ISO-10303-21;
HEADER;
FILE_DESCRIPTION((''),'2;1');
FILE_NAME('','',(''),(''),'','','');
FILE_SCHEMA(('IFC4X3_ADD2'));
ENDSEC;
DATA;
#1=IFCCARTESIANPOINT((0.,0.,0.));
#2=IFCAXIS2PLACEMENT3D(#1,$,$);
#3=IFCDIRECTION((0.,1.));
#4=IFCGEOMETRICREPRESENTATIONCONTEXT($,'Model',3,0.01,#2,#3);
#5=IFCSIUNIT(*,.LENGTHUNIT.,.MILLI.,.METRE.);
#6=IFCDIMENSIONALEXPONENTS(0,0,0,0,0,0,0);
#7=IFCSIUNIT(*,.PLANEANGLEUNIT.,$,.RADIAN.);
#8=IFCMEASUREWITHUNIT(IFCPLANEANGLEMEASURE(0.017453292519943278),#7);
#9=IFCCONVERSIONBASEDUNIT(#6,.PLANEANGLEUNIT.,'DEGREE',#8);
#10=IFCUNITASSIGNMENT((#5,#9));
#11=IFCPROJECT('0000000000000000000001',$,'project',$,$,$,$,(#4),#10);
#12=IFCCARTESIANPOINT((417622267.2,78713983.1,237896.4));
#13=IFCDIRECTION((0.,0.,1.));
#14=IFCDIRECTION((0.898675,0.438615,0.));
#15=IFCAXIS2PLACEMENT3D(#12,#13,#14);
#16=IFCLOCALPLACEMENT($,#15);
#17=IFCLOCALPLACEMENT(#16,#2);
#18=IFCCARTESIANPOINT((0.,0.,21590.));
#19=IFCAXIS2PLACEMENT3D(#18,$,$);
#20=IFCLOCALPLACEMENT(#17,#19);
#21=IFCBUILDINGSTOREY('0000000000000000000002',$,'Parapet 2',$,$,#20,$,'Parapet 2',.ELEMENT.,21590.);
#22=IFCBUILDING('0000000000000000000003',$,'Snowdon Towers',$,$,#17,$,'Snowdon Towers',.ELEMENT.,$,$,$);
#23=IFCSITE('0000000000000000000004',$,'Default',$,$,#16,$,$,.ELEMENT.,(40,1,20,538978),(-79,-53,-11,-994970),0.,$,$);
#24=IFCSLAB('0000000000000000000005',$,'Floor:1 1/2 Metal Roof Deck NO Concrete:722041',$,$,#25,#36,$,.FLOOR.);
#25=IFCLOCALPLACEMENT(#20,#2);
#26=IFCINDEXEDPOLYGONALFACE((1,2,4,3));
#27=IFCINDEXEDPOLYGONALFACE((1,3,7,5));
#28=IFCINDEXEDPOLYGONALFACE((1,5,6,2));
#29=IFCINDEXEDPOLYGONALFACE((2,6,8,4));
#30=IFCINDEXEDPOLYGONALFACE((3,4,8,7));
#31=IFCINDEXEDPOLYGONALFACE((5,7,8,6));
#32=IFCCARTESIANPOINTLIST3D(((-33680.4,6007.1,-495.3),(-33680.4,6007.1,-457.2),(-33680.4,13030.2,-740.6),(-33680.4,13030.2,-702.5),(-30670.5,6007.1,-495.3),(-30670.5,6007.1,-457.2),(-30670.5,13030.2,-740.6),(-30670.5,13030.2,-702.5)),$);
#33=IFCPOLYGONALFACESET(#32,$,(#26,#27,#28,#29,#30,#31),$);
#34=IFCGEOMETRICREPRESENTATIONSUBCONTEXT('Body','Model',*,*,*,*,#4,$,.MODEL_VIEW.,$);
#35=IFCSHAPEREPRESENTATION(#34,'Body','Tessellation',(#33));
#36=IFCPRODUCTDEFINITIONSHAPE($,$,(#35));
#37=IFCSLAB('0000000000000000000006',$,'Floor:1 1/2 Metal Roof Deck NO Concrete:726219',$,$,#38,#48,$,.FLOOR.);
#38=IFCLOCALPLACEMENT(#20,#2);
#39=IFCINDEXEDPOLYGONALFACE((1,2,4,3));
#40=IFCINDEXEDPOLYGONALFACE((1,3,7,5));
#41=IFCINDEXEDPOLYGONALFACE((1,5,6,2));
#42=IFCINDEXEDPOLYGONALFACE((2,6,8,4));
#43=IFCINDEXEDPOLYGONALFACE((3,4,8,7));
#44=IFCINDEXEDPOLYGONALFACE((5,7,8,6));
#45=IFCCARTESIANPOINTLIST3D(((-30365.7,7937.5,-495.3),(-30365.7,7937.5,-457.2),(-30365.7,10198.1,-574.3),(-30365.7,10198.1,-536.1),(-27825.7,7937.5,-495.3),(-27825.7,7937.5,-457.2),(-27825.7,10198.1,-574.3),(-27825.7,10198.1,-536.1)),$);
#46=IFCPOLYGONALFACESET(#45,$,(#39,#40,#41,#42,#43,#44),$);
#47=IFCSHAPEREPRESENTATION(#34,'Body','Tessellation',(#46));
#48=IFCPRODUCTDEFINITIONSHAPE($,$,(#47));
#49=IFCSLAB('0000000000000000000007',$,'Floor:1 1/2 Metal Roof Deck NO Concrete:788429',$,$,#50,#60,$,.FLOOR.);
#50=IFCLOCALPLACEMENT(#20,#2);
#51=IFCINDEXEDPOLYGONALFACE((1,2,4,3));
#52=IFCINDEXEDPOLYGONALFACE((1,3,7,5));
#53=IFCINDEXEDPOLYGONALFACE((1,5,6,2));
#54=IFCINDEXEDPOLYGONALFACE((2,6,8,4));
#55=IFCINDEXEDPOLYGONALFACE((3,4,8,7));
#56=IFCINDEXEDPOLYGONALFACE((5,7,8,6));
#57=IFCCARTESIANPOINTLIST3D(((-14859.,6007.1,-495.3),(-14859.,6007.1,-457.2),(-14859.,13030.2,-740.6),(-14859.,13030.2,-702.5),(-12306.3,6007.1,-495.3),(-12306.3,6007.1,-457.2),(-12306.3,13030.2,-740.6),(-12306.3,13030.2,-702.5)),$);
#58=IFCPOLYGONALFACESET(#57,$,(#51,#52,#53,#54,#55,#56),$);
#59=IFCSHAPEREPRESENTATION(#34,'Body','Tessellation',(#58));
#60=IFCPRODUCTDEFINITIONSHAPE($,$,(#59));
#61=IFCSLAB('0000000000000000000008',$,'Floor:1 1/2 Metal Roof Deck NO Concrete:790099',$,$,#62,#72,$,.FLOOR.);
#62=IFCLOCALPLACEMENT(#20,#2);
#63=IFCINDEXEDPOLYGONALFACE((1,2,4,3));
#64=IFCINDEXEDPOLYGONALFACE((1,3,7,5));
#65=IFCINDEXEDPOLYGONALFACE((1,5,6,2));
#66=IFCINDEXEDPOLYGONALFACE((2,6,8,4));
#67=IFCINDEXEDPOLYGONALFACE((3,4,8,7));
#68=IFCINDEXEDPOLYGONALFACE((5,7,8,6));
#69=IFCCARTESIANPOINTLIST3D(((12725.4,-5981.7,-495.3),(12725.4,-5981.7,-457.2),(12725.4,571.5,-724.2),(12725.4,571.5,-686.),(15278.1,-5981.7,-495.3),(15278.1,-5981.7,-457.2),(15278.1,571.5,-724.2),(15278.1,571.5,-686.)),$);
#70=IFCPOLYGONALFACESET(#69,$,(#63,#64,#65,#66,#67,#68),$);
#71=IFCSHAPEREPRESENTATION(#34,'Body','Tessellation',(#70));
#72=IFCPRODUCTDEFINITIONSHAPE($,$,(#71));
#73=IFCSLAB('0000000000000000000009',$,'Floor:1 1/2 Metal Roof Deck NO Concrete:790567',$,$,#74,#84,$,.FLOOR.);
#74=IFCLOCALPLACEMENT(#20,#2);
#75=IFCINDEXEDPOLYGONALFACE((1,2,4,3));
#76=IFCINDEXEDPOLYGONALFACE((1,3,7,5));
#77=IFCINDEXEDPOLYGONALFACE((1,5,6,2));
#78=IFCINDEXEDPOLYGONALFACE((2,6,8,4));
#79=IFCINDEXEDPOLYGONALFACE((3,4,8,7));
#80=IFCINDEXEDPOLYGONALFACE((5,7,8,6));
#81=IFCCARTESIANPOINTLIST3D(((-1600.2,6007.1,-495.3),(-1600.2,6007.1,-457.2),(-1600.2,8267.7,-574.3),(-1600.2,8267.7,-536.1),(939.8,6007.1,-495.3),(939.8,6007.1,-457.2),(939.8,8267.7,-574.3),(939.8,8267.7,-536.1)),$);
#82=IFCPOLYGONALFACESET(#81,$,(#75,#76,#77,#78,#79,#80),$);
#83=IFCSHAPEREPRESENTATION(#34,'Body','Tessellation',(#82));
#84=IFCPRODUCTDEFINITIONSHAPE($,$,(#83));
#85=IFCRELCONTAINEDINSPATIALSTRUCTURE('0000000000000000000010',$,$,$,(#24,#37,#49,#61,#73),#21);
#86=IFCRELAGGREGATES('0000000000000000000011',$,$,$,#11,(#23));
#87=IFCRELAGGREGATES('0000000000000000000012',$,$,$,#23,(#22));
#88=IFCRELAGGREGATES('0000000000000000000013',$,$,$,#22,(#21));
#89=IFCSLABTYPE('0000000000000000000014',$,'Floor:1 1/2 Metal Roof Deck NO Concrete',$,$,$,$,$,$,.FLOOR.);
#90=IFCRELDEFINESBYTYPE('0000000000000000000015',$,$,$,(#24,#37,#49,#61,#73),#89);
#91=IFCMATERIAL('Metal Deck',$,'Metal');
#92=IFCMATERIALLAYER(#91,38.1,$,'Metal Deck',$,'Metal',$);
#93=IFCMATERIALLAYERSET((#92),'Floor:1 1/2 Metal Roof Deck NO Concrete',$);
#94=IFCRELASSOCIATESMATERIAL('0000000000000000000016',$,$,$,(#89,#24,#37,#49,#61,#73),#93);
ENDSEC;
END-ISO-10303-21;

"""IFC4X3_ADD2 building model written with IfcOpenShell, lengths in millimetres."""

from ifc_helpers import new_model, entity, si_unit, converted_unit, direction, frame, frame_2d, origin, place, context, subcontext, project, spatial, rectangle, extrude, clip, halfspace, material, layer, layer_set, layer_usage, type_object, element, save


model = new_model("IFC4X3_ADD2")

# Units and contexts
model_context = context("Model", 3, precision=0.01, world=origin(), true_north=direction((0.0, 1.0)))
body_context = subcontext(model_context, "Body", "Model", "MODEL_VIEW")
ifc_project = project(units=[si_unit("LENGTHUNIT", "METRE", prefix="MILLI"), converted_unit("PLANEANGLEUNIT", "DEGREE", entity("IfcPlaneAngleMeasure", 0.017453292519943278), si_unit("PLANEANGLEUNIT", "RADIAN"), dimensions=[0, 0, 0, 0, 0, 0, 0])], contexts=[model_context])

# Site, building, storey
site_placement = place(None, frame((417622267.2, 78713983.1, 237896.4), z_axis=(0.0, 0.0, 1.0), x_axis=(0.898675, 0.438615, 0.0)))
site = spatial("IfcSite", under=ifc_project, at=site_placement, Name="Default", CompositionType="ELEMENT", RefLatitude=(40, 1, 20, 538978), RefLongitude=(-79, -53, -11, -994970), RefElevation=0.0)
building_placement = place(site_placement, origin())
building = spatial("IfcBuilding", under=site, at=building_placement, Name="Snowdon Towers", LongName="Snowdon Towers", CompositionType="ELEMENT")
storey_placement = place(building_placement, frame((0.0, 0.0, 21590.0)))
storey = spatial("IfcBuildingStorey", under=building, at=storey_placement, Name="Parapet 2", LongName="Parapet 2", CompositionType="ELEMENT", Elevation=21590.0)

# Slabs
ifc_material_1 = material(Name="Metal Deck", Category="Metal")
ifc_layer = layer(ifc_material_1, 38.1, Name="Metal Deck", Category="Metal")
ifc_layer_set = layer_set([ifc_layer], Name="Floor:1 1/2 Metal Roof Deck NO Concrete")
ifc_layer_usage_1 = layer_usage(ifc_layer_set, "AXIS3", "POSITIVE", 0.0)
slab_type = type_object("IfcSlabType", Name="Floor:1 1/2 Metal Roof Deck NO Concrete", PredefinedType="FLOOR", material=ifc_layer_set)
slab_1_placement = place(storey_placement, origin())
element("IfcSlab", 1, at=slab_1_placement, inside=storey, type_object=slab_type, material=ifc_layer_usage_1, Name="Floor:1 1/2 Metal Roof Deck NO Concrete:722041", PredefinedType="FLOOR", context=body_context, shape_type="Clipping", body=[
    clip(clip(extrude(rectangle(XDim=7027.4, YDim=3009.9, at=frame_2d((0.0, 0.0), x_axis=(1.0, 0.0))), frame((-32175.4, 9518.7, -579.8), z_axis=(0.0, -0.034899, -0.999391), x_axis=(0.0, 0.999391, -0.034899)), (0.034899, 0.0, 0.999391), 38.1), halfspace(frame((-30670.5, 6007.1, -495.3), z_axis=(0.0, -0.034899, -0.999391), x_axis=(0.0, -0.999391, 0.034899)), False)), halfspace(frame((-30670.5, 6007.1, -457.2), z_axis=(0.0, 0.034899, 0.999391), x_axis=(0.0, 0.999391, -0.034899)), False)),
])
ifc_layer_usage_2 = layer_usage(ifc_layer_set, "AXIS3", "POSITIVE", 0.0)
slab_2_placement = place(storey_placement, origin())
element("IfcSlab", 2, at=slab_2_placement, inside=storey, type_object=slab_type, material=ifc_layer_usage_2, Name="Floor:1 1/2 Metal Roof Deck NO Concrete:726219", PredefinedType="FLOOR", context=body_context, shape_type="Clipping", body=[
    clip(clip(extrude(rectangle(XDim=2262.0, YDim=2540.0, at=frame_2d((0.0, 0.0), x_axis=(1.0, 0.0))), frame((-29095.7, 9067.8, -496.7), z_axis=(0.0, -0.034899, -0.999391), x_axis=(0.0, 0.999391, -0.034899)), (0.034899, 0.0, 0.999391), 38.1), halfspace(frame((-27825.7, 7937.5, -495.3), z_axis=(0.0, -0.034899, -0.999391), x_axis=(0.0, -0.999391, 0.034899)), False)), halfspace(frame((-27825.7, 7937.5, -457.2), z_axis=(0.0, 0.034899, 0.999391), x_axis=(0.0, 0.999391, -0.034899)), False)),
])
ifc_layer_usage_3 = layer_usage(ifc_layer_set, "AXIS3", "POSITIVE", 0.0)
slab_3_placement = place(storey_placement, origin())
element("IfcSlab", 3, at=slab_3_placement, inside=storey, type_object=slab_type, material=ifc_layer_usage_3, Name="Floor:1 1/2 Metal Roof Deck NO Concrete:788429", PredefinedType="FLOOR", context=body_context, shape_type="Clipping", body=[
    clip(clip(extrude(rectangle(XDim=7027.4, YDim=2552.7, at=frame_2d((0.0, 0.0), x_axis=(1.0, 0.0))), frame((-13582.6, 9518.7, -579.8), z_axis=(0.0, -0.034899, -0.999391), x_axis=(0.0, 0.999391, -0.034899)), (0.034899, 0.0, 0.999391), 38.1), halfspace(frame((-12306.3, 6007.1, -495.3), z_axis=(0.0, -0.034899, -0.999391), x_axis=(0.0, -0.999391, 0.034899)), False)), halfspace(frame((-12306.3, 6007.1, -457.2), z_axis=(0.0, 0.034899, 0.999391), x_axis=(0.0, 0.999391, -0.034899)), False)),
])
ifc_layer_usage_4 = layer_usage(ifc_layer_set, "AXIS3", "POSITIVE", 0.0)
slab_4_placement = place(storey_placement, origin())
element("IfcSlab", 4, at=slab_4_placement, inside=storey, type_object=slab_type, material=ifc_layer_usage_4, Name="Floor:1 1/2 Metal Roof Deck NO Concrete:790099", PredefinedType="FLOOR", context=body_context, shape_type="Clipping", body=[
    clip(clip(extrude(rectangle(XDim=6557.2, YDim=2552.7, at=frame_2d((0.0, 0.0), x_axis=(1.0, 0.0))), frame((14001.8, -2705.1, -571.6), z_axis=(0.0, -0.034899, -0.999391), x_axis=(0.0, 0.999391, -0.034899)), (0.034899, 0.0, 0.999391), 38.1), halfspace(frame((15278.1, -5981.7, -495.3), z_axis=(0.0, -0.034899, -0.999391), x_axis=(0.0, -0.999391, 0.034899)), False)), halfspace(frame((15278.1, -5981.7, -457.2), z_axis=(0.0, 0.034899, 0.999391), x_axis=(0.0, 0.999391, -0.034899)), False)),
])
ifc_layer_usage_5 = layer_usage(ifc_layer_set, "AXIS3", "POSITIVE", 0.0)
slab_5_placement = place(storey_placement, origin())
element("IfcSlab", 5, at=slab_5_placement, inside=storey, type_object=slab_type, material=ifc_layer_usage_5, Name="Floor:1 1/2 Metal Roof Deck NO Concrete:790567", PredefinedType="FLOOR", context=body_context, shape_type="Clipping", body=[
    clip(clip(extrude(rectangle(XDim=2262.0, YDim=2540.0, at=frame_2d((0.0, 0.0), x_axis=(1.0, 0.0))), frame((-330.2, 7137.4, -496.7), z_axis=(0.0, -0.034899, -0.999391), x_axis=(0.0, 0.999391, -0.034899)), (0.034899, 0.0, 0.999391), 38.1), halfspace(frame((939.8, 6007.1, -495.3), z_axis=(0.0, -0.034899, -0.999391), x_axis=(0.0, -0.999391, 0.034899)), False)), halfspace(frame((939.8, 6007.1, -457.2), z_axis=(0.0, 0.034899, 0.999391), x_axis=(0.0, 0.999391, -0.034899)), False)),
])

save(model, "model.ifc")
